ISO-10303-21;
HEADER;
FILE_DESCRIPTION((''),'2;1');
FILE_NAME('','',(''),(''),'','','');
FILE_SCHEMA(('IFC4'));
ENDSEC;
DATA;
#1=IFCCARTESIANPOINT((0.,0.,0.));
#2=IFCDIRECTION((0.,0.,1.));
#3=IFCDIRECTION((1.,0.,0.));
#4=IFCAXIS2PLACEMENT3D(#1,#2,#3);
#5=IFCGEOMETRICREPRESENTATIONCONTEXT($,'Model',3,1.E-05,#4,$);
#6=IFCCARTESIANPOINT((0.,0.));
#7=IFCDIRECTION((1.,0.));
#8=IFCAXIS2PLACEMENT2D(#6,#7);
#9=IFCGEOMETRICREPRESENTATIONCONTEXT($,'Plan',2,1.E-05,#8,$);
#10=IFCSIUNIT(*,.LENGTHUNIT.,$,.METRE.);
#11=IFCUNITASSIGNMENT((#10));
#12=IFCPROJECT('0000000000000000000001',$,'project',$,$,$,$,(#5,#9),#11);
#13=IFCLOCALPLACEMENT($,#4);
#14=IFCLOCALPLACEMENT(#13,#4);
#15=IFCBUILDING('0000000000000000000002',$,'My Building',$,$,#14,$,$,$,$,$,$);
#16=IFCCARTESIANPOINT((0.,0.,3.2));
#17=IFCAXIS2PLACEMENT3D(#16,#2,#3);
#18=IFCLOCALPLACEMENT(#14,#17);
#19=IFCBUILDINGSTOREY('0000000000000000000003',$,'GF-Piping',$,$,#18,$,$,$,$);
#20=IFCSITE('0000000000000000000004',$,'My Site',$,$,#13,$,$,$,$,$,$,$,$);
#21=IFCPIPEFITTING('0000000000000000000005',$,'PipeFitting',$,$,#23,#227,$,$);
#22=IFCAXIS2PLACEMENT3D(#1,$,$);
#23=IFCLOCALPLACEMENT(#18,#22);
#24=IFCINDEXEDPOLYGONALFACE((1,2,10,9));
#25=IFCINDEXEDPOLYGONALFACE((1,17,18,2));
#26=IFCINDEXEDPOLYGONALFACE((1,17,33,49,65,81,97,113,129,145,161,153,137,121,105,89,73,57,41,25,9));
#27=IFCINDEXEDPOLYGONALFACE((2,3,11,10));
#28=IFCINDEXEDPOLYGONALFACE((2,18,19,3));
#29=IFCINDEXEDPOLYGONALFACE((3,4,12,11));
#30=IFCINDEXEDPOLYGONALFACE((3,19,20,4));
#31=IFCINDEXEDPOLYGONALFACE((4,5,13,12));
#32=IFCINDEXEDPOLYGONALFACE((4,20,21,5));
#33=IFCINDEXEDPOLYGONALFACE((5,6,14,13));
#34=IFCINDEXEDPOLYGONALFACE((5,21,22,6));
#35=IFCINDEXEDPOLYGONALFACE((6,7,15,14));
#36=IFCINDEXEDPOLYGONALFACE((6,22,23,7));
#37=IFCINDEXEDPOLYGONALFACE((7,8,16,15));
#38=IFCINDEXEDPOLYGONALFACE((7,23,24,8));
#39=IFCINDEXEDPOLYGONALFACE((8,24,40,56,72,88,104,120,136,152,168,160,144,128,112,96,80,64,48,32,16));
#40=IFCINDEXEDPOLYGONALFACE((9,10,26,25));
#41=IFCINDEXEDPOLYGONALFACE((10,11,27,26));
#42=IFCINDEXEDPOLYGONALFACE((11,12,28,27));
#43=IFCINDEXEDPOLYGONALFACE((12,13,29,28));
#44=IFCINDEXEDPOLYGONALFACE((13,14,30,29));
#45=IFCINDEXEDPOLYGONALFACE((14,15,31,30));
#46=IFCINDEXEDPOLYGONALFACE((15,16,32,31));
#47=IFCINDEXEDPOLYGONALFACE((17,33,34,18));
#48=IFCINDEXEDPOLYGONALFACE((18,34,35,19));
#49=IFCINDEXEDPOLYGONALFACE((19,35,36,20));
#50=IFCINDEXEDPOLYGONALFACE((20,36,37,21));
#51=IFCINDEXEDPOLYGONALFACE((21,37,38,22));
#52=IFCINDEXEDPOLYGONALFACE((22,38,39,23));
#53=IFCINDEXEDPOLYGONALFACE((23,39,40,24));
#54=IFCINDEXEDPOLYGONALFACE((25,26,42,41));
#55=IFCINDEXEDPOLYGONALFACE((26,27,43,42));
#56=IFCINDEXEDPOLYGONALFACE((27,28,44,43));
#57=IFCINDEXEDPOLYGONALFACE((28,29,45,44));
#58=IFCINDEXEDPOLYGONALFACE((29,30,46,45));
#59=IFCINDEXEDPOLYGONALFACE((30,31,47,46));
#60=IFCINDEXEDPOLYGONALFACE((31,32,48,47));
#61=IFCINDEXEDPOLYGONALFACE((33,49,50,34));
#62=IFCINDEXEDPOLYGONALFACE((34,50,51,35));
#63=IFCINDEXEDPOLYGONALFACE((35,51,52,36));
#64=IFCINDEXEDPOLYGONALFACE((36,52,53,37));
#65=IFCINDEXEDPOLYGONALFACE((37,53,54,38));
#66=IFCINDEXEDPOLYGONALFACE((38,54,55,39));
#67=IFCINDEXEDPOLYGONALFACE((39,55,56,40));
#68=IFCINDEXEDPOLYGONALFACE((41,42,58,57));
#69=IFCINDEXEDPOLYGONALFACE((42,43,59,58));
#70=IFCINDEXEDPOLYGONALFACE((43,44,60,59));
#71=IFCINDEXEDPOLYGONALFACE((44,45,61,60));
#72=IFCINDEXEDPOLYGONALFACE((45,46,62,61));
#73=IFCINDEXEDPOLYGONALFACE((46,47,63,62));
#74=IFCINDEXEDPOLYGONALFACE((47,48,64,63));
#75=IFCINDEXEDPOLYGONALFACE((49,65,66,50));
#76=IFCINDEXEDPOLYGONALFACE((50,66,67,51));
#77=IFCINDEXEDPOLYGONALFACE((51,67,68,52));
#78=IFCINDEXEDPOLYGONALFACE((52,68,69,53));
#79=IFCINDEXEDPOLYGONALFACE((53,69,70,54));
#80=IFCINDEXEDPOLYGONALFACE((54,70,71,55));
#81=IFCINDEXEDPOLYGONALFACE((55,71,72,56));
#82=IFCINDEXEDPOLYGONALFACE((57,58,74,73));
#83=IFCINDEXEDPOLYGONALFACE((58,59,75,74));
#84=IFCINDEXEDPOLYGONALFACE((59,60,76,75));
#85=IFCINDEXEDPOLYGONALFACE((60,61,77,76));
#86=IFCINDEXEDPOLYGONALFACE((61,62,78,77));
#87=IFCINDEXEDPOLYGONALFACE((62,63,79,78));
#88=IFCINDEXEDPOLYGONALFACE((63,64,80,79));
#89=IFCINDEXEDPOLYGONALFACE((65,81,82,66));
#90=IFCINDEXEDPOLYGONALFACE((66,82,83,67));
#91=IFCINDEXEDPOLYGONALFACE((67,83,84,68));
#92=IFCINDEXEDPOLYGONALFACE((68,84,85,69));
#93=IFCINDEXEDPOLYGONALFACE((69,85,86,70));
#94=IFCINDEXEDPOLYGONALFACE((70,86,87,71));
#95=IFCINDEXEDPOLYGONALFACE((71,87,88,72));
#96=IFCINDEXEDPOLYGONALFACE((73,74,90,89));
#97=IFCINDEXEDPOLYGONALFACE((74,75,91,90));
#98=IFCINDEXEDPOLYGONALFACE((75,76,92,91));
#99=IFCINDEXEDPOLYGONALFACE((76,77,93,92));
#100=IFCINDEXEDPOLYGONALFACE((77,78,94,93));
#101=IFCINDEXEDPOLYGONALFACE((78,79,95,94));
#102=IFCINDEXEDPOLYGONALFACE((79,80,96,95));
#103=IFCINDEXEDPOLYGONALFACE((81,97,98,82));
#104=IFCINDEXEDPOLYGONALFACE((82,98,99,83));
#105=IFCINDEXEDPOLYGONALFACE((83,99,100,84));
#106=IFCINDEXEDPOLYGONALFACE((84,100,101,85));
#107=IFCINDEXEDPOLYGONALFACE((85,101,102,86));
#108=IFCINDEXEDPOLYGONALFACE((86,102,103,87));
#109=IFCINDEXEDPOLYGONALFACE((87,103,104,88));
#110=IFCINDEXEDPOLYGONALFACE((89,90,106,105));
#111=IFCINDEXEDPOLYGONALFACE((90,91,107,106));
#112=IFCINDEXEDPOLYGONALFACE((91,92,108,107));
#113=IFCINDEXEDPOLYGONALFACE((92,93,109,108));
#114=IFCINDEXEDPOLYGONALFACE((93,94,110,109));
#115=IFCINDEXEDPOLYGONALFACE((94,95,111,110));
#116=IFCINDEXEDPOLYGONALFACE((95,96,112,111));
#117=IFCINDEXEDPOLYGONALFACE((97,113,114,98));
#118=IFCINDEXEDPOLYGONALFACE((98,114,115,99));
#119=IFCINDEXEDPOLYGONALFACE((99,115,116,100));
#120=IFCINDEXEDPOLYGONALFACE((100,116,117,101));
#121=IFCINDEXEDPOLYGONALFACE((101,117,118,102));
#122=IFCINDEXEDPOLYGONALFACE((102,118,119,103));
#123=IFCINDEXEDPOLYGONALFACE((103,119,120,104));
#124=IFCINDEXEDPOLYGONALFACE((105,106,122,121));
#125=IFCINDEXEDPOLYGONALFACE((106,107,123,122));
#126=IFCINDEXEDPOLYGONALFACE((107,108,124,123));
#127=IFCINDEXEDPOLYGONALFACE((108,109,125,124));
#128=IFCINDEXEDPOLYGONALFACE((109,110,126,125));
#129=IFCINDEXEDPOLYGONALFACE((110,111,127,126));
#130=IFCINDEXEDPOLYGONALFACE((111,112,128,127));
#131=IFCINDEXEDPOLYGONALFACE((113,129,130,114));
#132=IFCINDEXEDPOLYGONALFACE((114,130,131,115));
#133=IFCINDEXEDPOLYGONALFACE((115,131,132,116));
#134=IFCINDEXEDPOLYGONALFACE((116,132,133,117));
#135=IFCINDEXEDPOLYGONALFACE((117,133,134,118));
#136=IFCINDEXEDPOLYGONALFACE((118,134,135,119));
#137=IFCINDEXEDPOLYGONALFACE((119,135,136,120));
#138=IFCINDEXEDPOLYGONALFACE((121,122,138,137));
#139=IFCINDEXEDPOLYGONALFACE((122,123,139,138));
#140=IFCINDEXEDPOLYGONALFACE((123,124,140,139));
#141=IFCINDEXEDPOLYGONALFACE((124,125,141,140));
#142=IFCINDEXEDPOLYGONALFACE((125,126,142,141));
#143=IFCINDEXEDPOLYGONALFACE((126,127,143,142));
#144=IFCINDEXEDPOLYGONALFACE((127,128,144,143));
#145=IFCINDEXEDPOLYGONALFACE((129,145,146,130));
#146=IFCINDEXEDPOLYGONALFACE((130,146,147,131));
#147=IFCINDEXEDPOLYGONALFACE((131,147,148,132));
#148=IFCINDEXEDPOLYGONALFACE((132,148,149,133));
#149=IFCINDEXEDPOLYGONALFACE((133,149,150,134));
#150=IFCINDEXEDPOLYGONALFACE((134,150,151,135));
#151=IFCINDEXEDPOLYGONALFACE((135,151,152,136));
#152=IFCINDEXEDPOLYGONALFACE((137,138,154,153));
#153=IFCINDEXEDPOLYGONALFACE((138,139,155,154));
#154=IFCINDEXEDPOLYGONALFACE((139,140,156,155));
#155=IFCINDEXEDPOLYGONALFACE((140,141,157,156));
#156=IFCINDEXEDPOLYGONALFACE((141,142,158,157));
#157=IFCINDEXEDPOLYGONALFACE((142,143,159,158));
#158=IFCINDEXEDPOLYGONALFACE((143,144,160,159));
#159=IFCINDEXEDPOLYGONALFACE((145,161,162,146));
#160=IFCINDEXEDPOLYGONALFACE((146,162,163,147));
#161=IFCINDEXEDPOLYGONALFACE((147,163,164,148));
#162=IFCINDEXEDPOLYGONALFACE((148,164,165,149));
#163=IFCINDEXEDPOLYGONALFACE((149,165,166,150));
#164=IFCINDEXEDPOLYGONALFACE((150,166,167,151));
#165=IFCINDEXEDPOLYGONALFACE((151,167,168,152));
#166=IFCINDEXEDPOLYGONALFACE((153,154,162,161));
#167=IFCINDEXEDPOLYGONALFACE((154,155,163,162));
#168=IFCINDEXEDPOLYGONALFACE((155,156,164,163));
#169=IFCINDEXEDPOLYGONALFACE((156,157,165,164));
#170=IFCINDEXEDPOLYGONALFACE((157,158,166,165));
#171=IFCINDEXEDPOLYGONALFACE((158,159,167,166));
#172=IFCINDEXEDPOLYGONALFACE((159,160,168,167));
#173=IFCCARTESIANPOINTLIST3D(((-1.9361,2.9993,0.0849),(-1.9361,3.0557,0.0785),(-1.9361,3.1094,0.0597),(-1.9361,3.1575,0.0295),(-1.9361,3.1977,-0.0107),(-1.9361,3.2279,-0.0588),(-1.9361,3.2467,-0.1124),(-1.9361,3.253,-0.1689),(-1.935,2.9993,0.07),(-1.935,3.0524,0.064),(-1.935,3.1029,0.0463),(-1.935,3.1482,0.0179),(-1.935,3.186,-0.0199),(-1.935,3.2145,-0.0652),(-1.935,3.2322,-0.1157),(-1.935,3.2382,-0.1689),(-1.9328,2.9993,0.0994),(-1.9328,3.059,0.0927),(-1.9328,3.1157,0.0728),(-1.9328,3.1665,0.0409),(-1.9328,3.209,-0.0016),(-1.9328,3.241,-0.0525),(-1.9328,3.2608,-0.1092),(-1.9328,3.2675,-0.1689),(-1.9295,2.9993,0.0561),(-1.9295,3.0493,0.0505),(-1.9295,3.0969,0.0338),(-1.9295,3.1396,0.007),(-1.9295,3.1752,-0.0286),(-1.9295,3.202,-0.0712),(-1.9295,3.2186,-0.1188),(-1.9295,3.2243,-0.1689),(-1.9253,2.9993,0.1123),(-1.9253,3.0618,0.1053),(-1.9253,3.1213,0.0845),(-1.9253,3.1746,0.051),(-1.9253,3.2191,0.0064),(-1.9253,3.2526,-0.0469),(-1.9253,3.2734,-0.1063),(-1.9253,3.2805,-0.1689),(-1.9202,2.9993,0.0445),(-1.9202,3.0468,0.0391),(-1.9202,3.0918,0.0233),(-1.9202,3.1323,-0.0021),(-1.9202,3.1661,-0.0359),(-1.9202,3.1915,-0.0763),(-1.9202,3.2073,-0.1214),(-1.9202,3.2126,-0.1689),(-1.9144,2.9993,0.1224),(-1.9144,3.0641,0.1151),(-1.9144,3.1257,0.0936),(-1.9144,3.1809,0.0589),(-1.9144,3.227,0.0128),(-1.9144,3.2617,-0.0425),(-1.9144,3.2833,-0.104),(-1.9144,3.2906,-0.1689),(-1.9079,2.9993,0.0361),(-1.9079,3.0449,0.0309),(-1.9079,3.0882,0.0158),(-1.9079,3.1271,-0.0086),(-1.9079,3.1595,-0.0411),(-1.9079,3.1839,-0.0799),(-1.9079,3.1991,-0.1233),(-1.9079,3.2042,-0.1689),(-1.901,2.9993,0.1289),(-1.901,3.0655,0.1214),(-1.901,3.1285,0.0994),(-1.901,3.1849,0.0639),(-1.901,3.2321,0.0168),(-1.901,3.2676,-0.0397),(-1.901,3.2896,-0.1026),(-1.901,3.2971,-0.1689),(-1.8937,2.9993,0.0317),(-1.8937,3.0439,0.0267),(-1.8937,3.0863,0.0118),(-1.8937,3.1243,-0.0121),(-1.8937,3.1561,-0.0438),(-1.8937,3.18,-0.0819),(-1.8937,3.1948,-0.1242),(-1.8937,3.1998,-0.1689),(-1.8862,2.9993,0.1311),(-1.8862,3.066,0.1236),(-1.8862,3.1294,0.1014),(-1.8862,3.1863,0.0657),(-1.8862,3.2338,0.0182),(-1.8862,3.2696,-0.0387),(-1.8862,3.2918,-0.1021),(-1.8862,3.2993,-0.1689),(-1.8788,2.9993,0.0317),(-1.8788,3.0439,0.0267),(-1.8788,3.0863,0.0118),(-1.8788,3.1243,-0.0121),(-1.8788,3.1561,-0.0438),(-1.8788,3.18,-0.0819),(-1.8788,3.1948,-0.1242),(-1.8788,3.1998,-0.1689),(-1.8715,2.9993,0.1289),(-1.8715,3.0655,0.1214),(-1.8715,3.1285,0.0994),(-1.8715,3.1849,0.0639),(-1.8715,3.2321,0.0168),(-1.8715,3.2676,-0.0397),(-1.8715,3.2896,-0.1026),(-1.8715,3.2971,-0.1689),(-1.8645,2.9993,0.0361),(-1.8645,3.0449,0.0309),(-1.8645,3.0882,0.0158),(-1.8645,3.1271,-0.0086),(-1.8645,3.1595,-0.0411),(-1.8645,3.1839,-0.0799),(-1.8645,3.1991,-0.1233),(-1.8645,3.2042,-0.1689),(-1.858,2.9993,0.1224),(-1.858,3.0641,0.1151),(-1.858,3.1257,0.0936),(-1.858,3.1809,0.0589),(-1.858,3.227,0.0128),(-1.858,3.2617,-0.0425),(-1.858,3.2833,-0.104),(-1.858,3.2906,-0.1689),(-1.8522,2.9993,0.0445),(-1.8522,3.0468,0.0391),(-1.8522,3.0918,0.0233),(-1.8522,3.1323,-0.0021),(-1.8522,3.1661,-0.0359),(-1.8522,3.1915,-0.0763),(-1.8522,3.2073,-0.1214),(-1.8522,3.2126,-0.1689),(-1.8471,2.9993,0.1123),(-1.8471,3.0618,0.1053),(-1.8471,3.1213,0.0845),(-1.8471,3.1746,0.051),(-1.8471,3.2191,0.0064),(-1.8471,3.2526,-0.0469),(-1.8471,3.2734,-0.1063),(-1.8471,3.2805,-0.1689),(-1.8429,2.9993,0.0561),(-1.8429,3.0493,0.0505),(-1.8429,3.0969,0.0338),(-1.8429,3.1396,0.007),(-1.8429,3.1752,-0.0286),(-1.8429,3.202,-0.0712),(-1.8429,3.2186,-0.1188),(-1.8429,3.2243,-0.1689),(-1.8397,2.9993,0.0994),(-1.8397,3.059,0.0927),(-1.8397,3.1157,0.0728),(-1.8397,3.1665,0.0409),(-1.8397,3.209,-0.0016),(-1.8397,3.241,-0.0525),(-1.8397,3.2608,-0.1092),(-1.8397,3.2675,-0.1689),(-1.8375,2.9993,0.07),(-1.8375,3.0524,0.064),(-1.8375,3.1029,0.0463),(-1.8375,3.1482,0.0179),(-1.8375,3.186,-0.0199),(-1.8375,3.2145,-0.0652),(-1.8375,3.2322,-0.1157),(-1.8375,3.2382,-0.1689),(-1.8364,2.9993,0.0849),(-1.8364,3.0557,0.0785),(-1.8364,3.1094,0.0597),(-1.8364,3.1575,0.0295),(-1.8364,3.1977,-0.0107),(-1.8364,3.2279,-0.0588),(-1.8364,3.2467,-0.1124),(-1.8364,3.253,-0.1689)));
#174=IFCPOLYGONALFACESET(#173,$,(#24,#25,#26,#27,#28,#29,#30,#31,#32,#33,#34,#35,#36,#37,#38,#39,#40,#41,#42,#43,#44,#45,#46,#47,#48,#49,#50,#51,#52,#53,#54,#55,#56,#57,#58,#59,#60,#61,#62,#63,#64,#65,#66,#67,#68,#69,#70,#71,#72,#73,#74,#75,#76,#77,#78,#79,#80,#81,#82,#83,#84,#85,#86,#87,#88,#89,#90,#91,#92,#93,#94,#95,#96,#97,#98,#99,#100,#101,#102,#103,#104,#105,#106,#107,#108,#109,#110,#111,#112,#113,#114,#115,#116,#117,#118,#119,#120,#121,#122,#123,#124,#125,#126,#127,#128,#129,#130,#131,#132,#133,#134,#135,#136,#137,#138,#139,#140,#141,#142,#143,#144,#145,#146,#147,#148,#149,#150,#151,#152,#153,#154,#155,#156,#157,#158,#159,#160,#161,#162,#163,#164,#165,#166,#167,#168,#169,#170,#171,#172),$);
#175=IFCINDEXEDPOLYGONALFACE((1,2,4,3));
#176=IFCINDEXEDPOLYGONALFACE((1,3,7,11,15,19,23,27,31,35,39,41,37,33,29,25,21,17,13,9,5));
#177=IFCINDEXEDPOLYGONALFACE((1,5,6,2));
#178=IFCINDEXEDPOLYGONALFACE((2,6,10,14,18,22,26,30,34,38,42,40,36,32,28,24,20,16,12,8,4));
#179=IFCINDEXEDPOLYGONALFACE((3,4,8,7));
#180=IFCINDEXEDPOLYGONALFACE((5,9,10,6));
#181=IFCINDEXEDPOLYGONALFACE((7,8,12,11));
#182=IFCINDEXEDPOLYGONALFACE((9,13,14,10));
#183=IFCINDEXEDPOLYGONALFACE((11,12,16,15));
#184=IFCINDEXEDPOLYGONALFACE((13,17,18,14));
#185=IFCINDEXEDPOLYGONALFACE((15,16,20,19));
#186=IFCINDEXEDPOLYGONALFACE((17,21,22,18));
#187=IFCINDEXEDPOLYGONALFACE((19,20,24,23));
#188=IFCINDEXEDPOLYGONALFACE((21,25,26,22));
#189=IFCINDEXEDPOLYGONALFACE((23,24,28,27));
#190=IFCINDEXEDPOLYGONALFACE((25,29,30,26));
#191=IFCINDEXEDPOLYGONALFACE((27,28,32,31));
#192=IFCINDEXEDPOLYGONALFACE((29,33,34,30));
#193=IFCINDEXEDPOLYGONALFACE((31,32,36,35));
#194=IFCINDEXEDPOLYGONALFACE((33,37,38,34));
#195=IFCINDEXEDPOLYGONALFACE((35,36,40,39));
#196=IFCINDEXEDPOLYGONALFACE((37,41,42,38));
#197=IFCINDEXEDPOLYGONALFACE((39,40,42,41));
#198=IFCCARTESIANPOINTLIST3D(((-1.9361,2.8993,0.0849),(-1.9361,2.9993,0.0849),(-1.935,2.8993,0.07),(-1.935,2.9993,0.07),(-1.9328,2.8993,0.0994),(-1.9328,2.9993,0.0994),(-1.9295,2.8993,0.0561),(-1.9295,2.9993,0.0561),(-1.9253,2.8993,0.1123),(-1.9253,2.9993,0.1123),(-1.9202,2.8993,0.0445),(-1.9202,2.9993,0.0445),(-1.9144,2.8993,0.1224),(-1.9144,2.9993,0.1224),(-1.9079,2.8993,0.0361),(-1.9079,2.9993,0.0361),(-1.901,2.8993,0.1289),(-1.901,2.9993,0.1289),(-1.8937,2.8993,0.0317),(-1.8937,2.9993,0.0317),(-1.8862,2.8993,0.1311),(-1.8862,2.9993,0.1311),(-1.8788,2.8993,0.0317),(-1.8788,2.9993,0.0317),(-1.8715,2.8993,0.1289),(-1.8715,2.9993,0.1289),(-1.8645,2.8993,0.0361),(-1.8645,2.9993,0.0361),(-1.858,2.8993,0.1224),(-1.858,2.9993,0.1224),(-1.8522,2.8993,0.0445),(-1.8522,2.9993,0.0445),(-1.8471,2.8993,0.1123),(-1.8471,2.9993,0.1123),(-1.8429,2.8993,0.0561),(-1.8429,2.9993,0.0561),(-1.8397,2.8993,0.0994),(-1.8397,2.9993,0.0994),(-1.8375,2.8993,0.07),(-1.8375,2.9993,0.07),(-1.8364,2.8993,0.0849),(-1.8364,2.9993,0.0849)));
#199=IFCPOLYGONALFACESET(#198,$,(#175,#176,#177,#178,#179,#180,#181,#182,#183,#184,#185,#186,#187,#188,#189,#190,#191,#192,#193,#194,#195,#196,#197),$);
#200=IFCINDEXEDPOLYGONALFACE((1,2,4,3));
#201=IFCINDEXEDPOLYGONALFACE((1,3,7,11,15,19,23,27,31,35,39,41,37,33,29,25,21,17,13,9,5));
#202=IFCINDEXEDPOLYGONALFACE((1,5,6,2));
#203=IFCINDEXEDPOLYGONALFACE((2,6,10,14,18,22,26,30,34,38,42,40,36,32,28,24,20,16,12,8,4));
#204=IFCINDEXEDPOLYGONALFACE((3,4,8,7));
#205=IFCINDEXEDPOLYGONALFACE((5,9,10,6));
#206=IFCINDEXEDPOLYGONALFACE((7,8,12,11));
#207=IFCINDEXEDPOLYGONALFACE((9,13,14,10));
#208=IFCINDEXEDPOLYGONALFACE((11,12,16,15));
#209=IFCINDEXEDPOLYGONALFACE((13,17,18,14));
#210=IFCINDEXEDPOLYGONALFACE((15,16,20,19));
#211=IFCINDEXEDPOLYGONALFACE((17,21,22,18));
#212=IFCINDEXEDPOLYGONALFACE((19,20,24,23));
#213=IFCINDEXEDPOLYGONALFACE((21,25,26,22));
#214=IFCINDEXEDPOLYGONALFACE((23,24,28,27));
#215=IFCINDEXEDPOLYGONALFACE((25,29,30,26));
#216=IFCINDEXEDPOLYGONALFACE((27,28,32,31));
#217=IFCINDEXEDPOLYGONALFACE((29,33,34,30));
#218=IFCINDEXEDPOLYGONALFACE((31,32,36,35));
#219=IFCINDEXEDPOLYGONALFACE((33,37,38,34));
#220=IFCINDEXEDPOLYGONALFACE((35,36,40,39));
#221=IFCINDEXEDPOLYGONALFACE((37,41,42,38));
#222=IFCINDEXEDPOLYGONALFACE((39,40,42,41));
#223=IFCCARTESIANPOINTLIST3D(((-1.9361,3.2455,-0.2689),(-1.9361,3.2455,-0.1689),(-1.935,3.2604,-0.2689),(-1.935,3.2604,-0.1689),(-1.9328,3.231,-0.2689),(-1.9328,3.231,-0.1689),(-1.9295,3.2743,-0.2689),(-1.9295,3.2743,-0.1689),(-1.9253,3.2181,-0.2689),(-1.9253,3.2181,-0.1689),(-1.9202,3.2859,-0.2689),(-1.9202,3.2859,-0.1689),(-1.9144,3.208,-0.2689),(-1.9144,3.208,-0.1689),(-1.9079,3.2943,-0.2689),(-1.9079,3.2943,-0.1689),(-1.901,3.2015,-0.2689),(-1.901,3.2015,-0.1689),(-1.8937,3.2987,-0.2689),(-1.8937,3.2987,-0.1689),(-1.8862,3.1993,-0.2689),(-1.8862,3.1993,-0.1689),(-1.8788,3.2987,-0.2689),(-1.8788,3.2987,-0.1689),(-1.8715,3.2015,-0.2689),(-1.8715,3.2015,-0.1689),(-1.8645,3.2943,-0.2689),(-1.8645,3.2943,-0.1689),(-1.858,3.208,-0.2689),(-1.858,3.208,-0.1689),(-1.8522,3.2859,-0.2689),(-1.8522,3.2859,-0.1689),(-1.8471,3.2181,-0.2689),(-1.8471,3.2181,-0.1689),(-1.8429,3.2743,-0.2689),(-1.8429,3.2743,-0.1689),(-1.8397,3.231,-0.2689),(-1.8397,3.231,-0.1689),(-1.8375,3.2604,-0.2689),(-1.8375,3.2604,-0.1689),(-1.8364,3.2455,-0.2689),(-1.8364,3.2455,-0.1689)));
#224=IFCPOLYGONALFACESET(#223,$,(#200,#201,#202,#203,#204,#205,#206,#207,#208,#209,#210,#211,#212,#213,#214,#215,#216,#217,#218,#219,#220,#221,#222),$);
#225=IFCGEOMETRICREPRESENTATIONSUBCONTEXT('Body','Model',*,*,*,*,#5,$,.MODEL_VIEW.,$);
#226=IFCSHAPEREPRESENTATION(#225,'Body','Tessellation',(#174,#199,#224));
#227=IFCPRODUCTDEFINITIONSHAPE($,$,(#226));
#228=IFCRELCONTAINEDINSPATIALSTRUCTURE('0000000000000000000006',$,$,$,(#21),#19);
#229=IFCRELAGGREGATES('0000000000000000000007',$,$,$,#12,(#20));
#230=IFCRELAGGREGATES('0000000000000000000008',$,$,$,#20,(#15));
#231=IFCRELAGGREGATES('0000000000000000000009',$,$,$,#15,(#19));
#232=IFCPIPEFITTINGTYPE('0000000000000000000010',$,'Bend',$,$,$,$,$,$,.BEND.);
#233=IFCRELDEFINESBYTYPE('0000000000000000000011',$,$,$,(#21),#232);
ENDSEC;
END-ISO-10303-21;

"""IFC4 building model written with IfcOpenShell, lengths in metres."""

from ifc_helpers import new_model, entity, si_unit, frame, origin_with_axes, origin_2d_with_axis, place, context, subcontext, project, spatial, circle, extrude, source, transform, mapped, type_object, type_shapes, element, save


model = new_model("IFC4")

# Units and contexts
model_context = context("Model", 3, precision=1e-05, world=origin_with_axes())
plan_context = context("Plan", 2, precision=1e-05, world=origin_2d_with_axis())
body_context = subcontext(model_context, "Body", "Model", "MODEL_VIEW")
ifc_project = project(units=[si_unit("LENGTHUNIT", "METRE")], contexts=[model_context, plan_context])

# Site, building, storey
site_placement = place(None, origin_with_axes())
site = spatial("IfcSite", under=ifc_project, at=site_placement, Name="My Site")
building_placement = place(site_placement, origin_with_axes())
building = spatial("IfcBuilding", under=site, at=building_placement, Name="My Building")
storey_placement = place(building_placement, frame((0.0, 0.0, 3.2), z_axis=(0.0, 0.0, 1.0), x_axis=(1.0, 0.0, 0.0)))
storey = spatial("IfcBuildingStorey", under=building, at=storey_placement, Name="GF-Piping")

# Pipe fitting
pipe_fitting_type = type_object("IfcPipeFittingType", Name="Bend", PredefinedType="BEND")
shared_shape = source(origin_with_axes(), body_context, "Body", "SolidModel", [
    entity("IfcSweptDiskSolid", entity("IfcIndexedPolyCurve", entity("IfcCartesianPointList3D", [[0.0, 0.0, 0.1], [-0.0732, 0.0, 0.2768], [-0.25, 0.0, 0.35]]), [entity("IfcArcIndex", [1, 2, 3])]), 0.05),
    extrude(circle(Radius=0.05), origin_with_axes(), (0.0, 0.0, 1.0), 0.1),
    extrude(circle(Radius=0.05), frame((-0.25, 0.0, 0.35), z_axis=(-1.0, 0.0, 0.0), x_axis=(0.0, 0.0, -1.0)), (0.0, 0.0, 1.0), 0.1),
])
type_shapes(pipe_fitting_type, [shared_shape])
for number, where, z_axis, x_axis, name in (
    (1, (-1.8862, 2.8993, 0.0811), (0.0, 1.0, 0.0), (0.0, 0.0, 1.0), "PipeFitting"),
):
    element("IfcPipeFitting", number, at=place(storey_placement, frame(where, z_axis=z_axis, x_axis=x_axis)), inside=storey, type_object=pipe_fitting_type, Name=name, context=body_context, shape_type="MappedRepresentation", body=[
        mapped(shared_shape, transform((0.0, 0.0, 0.0), x_axis=(1.0, 0.0, 0.0), y_axis=(0.0, 1.0, 0.0), z_axis=(0.0, 0.0, 1.0), scale=1.0)),
    ])

save(model, "model.ifc")
